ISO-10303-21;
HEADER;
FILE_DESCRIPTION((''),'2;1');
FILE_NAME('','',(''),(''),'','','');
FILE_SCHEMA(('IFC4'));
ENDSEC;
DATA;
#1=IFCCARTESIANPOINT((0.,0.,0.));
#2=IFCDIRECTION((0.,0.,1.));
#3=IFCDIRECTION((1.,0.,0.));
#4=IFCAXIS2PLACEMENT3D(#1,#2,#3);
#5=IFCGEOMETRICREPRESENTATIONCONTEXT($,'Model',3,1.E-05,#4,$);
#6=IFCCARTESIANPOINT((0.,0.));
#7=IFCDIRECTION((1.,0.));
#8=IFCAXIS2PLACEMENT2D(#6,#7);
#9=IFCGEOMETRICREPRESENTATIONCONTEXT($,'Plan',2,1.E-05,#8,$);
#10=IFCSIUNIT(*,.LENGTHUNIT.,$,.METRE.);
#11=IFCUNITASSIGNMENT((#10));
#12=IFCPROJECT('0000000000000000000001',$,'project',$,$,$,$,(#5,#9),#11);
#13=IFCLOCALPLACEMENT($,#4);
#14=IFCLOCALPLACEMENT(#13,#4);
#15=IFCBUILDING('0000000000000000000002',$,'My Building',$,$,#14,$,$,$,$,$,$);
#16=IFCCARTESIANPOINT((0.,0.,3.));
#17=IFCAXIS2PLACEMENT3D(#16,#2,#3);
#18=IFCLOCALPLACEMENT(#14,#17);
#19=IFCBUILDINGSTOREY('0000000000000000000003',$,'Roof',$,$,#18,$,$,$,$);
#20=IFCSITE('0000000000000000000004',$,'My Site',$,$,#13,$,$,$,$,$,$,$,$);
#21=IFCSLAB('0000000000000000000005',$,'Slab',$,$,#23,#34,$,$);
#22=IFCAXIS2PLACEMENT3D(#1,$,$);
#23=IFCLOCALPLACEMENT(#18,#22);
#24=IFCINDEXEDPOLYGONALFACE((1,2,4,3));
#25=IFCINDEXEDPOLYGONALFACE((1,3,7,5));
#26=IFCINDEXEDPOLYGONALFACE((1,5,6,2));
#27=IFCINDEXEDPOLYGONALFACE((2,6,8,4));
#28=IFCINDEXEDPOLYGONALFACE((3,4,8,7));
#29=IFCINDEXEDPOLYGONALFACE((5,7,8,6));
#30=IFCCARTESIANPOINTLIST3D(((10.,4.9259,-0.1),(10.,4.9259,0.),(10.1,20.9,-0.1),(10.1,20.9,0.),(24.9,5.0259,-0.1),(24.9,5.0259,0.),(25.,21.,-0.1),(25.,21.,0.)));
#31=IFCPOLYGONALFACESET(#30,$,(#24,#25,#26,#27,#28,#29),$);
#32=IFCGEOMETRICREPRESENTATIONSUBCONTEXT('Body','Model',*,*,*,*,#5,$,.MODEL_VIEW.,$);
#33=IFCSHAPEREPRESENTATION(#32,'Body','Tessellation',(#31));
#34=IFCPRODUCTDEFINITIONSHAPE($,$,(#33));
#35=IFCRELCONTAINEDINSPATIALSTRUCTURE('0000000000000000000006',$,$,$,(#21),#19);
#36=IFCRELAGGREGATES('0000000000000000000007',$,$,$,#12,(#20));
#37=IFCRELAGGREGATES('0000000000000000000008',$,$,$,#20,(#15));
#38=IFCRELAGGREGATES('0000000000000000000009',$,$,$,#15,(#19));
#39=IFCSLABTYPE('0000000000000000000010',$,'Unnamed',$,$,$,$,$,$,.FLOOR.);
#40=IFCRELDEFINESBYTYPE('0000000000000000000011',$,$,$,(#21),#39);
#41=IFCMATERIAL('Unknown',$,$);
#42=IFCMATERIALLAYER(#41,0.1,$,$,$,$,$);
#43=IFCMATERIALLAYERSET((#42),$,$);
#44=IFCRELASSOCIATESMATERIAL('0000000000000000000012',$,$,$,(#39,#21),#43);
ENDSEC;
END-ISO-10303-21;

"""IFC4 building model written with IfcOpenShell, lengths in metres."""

from ifc_helpers import new_model, si_unit, frame, origin_with_axes, origin_2d_with_axis, place, context, subcontext, project, spatial, indexed_curve, outline, extrude, material, layer, layer_set, layer_usage, type_object, element, save


model = new_model("IFC4")

# Units and contexts
model_context = context("Model", 3, precision=1e-05, world=origin_with_axes())
plan_context = context("Plan", 2, precision=1e-05, world=origin_2d_with_axis())
body_context = subcontext(model_context, "Body", "Model", "MODEL_VIEW")
ifc_project = project(units=[si_unit("LENGTHUNIT", "METRE")], contexts=[model_context, plan_context])

# Site, building, storey
site_placement = place(None, origin_with_axes())
site = spatial("IfcSite", under=ifc_project, at=site_placement, Name="My Site")
building_placement = place(site_placement, origin_with_axes())
building = spatial("IfcBuilding", under=site, at=building_placement, Name="My Building")
storey_placement = place(building_placement, frame((0.0, 0.0, 3.0), z_axis=(0.0, 0.0, 1.0), x_axis=(1.0, 0.0, 0.0)))
storey = spatial("IfcBuildingStorey", under=building, at=storey_placement, Name="Roof")

# Slab
ifc_material = material(Name="Unknown")
ifc_layer = layer(ifc_material, 0.1)
ifc_layer_set = layer_set([ifc_layer])
ifc_layer_usage = layer_usage(ifc_layer_set, "AXIS3", "POSITIVE", -0.1)
slab_type = type_object("IfcSlabType", Name="Unnamed", PredefinedType="FLOOR", material=ifc_layer_set)
slab_placement = place(storey_placement, frame((10.1, 20.9, 0.0), z_axis=(0.0, 0.0, 1.0), x_axis=(1.0, 0.0, 0.0)))
element("IfcSlab", 1, at=slab_placement, inside=storey, type_object=slab_type, material=ifc_layer_usage, Name="Slab", context=body_context, shape_type="SweptSolid", body=[
    extrude(outline(indexed_curve([(0.0, 0.0), (14.9, 0.1), (14.8, -15.8741), (-0.1, -15.9741), (0.0, 0.0)])), frame((0.0, 0.0, -0.1), z_axis=(0.0, 0.0, 1.0), x_axis=(1.0, 0.0, 0.0)), (0.0, 0.0, 1.0), 0.1),
])

save(model, "model.ifc")
